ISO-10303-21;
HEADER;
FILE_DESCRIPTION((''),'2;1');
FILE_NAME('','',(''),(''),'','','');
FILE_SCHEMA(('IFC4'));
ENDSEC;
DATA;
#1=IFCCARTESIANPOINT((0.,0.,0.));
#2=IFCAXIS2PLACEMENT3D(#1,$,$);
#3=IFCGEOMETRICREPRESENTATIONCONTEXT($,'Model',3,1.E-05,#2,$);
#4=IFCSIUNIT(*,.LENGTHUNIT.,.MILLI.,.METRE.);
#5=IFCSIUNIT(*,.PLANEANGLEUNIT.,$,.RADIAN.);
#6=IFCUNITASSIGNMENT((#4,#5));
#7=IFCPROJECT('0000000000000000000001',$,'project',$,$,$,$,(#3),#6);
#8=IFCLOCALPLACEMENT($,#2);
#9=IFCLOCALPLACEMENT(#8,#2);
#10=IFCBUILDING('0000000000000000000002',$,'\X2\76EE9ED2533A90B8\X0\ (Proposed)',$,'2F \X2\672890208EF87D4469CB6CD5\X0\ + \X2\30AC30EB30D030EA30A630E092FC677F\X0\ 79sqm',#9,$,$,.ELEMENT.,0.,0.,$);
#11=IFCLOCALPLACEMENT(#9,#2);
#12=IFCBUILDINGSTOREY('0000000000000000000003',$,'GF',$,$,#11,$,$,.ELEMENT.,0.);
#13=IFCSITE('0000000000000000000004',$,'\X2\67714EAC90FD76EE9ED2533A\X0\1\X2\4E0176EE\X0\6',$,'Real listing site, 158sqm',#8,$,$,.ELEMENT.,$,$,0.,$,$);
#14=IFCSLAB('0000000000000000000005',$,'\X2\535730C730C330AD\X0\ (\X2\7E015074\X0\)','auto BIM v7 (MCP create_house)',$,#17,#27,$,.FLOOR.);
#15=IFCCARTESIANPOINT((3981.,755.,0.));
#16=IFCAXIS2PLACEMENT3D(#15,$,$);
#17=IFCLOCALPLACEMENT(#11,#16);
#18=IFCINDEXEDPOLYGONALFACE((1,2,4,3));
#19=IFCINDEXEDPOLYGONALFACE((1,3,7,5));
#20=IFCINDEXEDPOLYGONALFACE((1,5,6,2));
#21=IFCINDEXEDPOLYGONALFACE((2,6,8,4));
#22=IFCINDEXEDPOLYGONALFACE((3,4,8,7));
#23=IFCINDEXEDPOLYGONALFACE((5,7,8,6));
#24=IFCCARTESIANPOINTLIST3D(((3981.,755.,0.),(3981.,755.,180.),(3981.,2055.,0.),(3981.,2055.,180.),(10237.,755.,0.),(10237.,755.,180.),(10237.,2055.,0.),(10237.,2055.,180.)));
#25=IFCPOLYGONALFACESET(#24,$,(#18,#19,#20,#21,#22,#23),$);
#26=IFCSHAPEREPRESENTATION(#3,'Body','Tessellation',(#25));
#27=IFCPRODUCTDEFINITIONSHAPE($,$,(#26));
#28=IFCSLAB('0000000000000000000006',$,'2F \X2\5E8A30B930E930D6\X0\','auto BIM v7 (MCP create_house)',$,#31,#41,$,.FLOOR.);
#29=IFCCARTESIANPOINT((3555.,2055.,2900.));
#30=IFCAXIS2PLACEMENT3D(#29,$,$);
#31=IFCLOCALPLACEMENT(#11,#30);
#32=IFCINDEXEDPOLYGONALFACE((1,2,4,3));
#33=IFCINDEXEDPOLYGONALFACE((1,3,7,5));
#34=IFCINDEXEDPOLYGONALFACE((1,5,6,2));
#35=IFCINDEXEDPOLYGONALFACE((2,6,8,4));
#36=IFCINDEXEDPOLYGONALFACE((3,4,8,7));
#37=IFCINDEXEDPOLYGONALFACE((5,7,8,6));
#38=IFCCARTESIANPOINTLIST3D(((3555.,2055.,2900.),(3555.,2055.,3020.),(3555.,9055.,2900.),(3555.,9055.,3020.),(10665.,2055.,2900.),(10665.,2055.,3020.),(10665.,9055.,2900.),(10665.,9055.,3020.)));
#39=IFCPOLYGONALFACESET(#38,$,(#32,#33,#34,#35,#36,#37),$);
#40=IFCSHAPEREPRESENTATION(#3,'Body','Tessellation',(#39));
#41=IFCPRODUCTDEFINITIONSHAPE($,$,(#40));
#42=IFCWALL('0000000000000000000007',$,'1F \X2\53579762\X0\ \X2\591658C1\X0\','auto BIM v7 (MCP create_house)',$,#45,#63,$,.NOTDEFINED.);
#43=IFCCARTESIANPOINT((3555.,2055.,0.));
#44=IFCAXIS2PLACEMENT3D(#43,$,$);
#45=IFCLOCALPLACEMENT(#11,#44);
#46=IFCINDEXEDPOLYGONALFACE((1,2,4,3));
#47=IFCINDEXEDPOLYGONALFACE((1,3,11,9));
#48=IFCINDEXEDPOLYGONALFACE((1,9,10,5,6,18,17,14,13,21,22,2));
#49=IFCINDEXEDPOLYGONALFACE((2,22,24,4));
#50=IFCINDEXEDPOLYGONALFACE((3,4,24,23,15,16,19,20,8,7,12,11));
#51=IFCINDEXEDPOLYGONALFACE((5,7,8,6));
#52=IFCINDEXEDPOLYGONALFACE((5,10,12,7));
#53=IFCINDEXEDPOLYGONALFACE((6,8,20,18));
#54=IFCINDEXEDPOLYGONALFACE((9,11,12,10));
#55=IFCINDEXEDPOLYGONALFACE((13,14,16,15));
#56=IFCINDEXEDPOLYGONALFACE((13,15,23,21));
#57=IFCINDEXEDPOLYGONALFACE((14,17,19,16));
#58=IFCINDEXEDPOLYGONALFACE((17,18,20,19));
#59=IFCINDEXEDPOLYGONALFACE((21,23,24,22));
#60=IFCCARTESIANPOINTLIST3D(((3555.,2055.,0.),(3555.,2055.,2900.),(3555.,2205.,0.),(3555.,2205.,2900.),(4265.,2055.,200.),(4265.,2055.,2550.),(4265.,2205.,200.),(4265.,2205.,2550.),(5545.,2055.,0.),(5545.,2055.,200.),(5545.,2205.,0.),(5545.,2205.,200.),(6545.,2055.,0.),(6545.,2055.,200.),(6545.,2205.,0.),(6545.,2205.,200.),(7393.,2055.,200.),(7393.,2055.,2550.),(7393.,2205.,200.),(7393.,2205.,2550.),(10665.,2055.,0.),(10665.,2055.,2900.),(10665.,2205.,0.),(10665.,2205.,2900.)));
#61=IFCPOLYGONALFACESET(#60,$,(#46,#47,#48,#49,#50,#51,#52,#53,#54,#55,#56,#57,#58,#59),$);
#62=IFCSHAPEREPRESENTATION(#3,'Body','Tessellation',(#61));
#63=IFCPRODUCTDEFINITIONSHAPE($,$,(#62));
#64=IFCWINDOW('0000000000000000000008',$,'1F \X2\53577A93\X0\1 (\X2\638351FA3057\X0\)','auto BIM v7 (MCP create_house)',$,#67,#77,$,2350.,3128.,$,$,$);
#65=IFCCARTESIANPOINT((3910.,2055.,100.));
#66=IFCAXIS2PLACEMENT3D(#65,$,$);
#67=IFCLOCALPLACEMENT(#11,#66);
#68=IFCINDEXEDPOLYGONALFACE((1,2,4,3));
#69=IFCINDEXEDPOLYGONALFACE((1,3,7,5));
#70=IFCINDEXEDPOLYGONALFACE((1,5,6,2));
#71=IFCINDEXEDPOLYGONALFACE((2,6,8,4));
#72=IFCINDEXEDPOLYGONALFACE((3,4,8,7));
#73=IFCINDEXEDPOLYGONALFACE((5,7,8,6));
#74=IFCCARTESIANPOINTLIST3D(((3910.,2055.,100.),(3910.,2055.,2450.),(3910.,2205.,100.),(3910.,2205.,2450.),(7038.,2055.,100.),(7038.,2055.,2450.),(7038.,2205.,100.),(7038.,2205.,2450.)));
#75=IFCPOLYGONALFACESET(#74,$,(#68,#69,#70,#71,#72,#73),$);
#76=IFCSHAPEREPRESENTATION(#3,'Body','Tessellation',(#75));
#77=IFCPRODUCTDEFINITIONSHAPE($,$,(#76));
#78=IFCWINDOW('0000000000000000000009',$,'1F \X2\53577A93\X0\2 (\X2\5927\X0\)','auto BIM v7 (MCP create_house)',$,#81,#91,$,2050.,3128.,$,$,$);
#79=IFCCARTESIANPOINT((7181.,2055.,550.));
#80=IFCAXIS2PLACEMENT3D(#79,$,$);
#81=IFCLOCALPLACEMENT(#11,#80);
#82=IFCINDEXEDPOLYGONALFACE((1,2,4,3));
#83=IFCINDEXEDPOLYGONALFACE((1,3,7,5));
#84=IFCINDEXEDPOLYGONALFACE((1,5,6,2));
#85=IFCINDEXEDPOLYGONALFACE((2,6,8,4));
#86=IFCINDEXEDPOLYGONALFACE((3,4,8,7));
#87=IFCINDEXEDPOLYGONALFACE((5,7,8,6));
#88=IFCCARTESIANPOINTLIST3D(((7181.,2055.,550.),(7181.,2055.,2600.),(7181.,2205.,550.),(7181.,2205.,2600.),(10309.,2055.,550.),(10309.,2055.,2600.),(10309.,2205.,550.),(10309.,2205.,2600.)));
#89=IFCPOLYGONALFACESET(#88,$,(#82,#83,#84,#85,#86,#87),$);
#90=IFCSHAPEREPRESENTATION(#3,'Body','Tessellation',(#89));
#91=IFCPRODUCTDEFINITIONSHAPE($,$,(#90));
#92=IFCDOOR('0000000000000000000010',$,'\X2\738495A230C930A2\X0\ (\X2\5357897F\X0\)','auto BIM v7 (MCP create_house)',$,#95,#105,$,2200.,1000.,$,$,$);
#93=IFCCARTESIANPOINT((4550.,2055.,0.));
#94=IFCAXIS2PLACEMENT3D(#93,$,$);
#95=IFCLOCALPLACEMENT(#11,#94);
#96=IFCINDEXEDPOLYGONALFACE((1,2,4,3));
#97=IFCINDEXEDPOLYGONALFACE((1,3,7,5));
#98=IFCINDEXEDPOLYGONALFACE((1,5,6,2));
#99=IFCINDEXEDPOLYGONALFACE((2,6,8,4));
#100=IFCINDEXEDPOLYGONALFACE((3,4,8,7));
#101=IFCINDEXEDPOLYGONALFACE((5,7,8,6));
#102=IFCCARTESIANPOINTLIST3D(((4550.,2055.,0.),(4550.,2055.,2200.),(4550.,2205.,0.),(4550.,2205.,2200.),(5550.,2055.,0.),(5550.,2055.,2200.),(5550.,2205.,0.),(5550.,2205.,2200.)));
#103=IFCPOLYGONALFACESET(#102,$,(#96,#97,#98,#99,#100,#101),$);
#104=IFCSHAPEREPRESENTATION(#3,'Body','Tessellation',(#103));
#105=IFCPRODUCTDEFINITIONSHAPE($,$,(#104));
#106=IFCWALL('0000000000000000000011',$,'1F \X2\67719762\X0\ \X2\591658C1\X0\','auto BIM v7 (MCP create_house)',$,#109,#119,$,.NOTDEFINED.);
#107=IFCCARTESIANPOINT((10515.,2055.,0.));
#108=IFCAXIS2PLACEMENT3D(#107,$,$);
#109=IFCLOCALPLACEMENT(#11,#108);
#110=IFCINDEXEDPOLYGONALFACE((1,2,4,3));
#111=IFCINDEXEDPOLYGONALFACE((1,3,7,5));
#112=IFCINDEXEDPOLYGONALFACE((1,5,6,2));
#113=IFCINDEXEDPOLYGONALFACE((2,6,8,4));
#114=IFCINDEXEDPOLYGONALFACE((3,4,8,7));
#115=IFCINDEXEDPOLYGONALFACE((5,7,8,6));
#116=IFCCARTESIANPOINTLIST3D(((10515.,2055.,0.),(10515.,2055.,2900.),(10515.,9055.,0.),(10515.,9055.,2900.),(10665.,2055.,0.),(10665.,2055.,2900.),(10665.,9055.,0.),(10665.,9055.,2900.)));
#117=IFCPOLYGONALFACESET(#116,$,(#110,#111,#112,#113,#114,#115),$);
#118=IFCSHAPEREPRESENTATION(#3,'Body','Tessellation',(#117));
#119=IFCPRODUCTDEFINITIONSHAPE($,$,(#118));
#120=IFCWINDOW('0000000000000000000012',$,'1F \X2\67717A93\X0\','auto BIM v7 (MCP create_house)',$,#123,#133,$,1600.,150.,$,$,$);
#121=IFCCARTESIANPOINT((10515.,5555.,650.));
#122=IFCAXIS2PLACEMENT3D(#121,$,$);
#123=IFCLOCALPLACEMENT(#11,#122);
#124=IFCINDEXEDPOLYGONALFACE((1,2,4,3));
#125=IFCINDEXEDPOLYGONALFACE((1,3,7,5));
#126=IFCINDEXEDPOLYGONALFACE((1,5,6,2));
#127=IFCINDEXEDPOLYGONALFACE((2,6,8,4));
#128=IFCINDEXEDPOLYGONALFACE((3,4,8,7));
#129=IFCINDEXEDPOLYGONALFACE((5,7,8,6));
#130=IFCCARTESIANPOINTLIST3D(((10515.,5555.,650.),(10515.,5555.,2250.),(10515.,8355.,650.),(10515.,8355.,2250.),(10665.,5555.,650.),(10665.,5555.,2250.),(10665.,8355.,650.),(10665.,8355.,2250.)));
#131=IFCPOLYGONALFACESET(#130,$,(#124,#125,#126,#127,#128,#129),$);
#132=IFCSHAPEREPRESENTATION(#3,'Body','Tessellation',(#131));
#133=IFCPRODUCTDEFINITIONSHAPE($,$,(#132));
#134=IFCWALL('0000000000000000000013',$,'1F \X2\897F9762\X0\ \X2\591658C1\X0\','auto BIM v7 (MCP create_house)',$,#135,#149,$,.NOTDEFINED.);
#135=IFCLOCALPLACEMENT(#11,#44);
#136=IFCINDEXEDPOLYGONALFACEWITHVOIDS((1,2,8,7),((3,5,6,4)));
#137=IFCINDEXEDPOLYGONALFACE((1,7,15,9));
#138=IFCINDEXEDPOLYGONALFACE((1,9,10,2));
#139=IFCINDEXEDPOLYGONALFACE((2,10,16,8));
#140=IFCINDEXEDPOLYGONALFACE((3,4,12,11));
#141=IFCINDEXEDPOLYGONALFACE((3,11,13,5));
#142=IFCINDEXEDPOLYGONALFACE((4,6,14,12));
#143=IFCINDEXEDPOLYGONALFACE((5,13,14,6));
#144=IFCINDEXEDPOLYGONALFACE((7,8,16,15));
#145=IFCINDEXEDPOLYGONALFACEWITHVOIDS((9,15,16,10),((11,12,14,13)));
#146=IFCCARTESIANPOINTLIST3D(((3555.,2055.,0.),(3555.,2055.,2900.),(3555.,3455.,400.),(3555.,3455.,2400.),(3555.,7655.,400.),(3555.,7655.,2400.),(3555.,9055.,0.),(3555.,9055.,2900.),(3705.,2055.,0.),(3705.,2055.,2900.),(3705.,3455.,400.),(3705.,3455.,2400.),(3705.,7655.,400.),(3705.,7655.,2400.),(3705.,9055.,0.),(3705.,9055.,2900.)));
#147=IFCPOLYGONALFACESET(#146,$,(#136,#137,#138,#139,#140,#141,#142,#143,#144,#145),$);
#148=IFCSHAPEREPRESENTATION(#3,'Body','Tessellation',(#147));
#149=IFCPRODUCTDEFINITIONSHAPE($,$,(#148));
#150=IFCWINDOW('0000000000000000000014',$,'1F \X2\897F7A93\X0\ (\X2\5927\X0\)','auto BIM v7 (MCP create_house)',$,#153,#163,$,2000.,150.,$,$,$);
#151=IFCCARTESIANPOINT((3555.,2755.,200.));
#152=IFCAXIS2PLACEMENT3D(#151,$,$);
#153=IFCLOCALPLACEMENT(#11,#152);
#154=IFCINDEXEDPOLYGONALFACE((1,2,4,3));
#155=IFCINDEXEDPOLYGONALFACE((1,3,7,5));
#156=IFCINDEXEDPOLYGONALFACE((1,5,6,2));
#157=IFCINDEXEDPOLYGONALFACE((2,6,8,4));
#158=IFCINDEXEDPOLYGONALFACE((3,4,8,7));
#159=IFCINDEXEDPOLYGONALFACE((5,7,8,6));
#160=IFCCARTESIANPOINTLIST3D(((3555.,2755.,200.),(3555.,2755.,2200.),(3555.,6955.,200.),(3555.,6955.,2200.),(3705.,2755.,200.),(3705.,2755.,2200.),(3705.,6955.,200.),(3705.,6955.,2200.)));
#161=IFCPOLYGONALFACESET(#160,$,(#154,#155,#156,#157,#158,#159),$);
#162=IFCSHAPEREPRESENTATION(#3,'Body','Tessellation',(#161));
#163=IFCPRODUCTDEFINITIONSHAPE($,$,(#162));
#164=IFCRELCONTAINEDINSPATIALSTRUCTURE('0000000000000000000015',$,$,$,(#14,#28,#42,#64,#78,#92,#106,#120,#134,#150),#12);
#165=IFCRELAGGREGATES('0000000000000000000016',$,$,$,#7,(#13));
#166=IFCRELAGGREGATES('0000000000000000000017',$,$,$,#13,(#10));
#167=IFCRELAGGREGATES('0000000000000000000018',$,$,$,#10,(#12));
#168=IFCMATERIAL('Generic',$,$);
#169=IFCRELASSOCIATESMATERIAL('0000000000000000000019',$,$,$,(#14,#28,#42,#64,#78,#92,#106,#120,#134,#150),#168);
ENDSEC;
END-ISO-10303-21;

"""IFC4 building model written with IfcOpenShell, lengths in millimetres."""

from ifc_helpers import new_model, si_unit, frame, frame_2d, origin, place, context, project, spatial, rectangle, extrude, material, element, fill, save


model = new_model("IFC4")

# Units and contexts
model_context = context("Model", 3, precision=1e-05, world=origin())
ifc_project = project(units=[si_unit("LENGTHUNIT", "METRE", prefix="MILLI"), si_unit("PLANEANGLEUNIT", "RADIAN")], contexts=[model_context])

# Site, building, storey
site_placement = place(None, origin())
site = spatial("IfcSite", under=ifc_project, at=site_placement, Name="東京都目黒区1丁目6", ObjectType="Real listing site, 158sqm", CompositionType="ELEMENT", RefElevation=0.0)
building_placement = place(site_placement, origin())
building = spatial("IfcBuilding", under=site, at=building_placement, Name="目黒区邸 (Proposed)", ObjectType="2F 木造軸組構法 + ガルバリウム鋼板 79sqm", CompositionType="ELEMENT", ElevationOfRefHeight=0.0, ElevationOfTerrain=0.0)
storey_placement = place(building_placement, origin())
storey = spatial("IfcBuildingStorey", under=building, at=storey_placement, Name="GF", CompositionType="ELEMENT", Elevation=0.0)

# Slabs
ifc_material = material(Name="Generic")
slab_1_placement = place(storey_placement, frame((3981.0, 755.0, 0.0)))
element("IfcSlab", 1, at=slab_1_placement, inside=storey, material=ifc_material, Name="南デッキ (縁側)", Description="auto BIM v7 (MCP create_house)", PredefinedType="FLOOR", context=model_context, shape_type="SweptSolid", body=[
    extrude(rectangle(XDim=6256.0, YDim=1300.0, at=frame_2d((3128.0, 650.0))), frame((3981.0, 755.0, 0.0)), (0.0, 0.0, 1.0), 180.0),
])
slab_2_placement = place(storey_placement, frame((3555.0, 2055.0, 2900.0)))
element("IfcSlab", 2, at=slab_2_placement, inside=storey, material=ifc_material, Name="2F 床スラブ", Description="auto BIM v7 (MCP create_house)", PredefinedType="FLOOR", context=model_context, shape_type="SweptSolid", body=[
    extrude(rectangle(XDim=7110.0, YDim=7000.0, at=frame_2d((3555.0, 3500.0))), frame((3555.0, 2055.0, 2900.0)), (0.0, 0.0, 1.0), 120.0),
])

# Wall, openings, windows, door
wall_1_placement = place(storey_placement, frame((3555.0, 2055.0, 0.0)))
wall_1 = element("IfcWall", 3, at=wall_1_placement, inside=storey, material=ifc_material, Name="1F 南面 外壁", Description="auto BIM v7 (MCP create_house)", PredefinedType="NOTDEFINED", context=model_context, shape_type="SweptSolid", body=[
    extrude(rectangle(XDim=7110.0, YDim=150.0, at=frame_2d((3555.0, 75.0))), frame((3555.0, 2055.0, 0.0)), (0.0, 0.0, 1.0), 2900.0),
])
opening_1_placement = place(storey_placement, frame((3910.0, 2055.0, 100.0)))
opening_1 = element("IfcOpeningElement", 4, at=opening_1_placement, cuts=wall_1, PredefinedType="NOTDEFINED", context=model_context, shape_type="SweptSolid", body=[
    extrude(rectangle(XDim=3128.0, YDim=150.0, at=frame_2d((1564.0, 75.0))), frame((3910.0, 2055.0, 100.0)), (0.0, 0.0, 1.0), 2350.0),
])
opening_2_placement = place(storey_placement, frame((7181.0, 2055.0, 550.0)))
opening_2 = element("IfcOpeningElement", 5, at=opening_2_placement, cuts=wall_1, PredefinedType="NOTDEFINED", context=model_context, shape_type="SweptSolid", body=[
    extrude(rectangle(XDim=3128.0, YDim=150.0, at=frame_2d((1564.0, 75.0))), frame((7181.0, 2055.0, 550.0)), (0.0, 0.0, 1.0), 2050.0),
])
opening_3_placement = place(storey_placement, frame((4550.0, 2055.0, 0.0)))
opening_3 = element("IfcOpeningElement", 6, at=opening_3_placement, cuts=wall_1, PredefinedType="NOTDEFINED", context=model_context, shape_type="SweptSolid", body=[
    extrude(rectangle(XDim=1000.0, YDim=150.0, at=frame_2d((500.0, 75.0))), frame((4550.0, 2055.0, 0.0)), (0.0, 0.0, 1.0), 2200.0),
])
window_1_placement = place(storey_placement, frame((3910.0, 2055.0, 100.0)))
window_1 = element("IfcWindow", 7, at=window_1_placement, inside=storey, material=ifc_material, Name="1F 南窓1 (掃出し)", Description="auto BIM v7 (MCP create_house)", OverallHeight=2350.0, OverallWidth=3128.0, context=model_context, shape_type="SweptSolid", body=[
    extrude(rectangle(XDim=3128.0, YDim=150.0, at=frame_2d((1564.0, 75.0))), frame((3910.0, 2055.0, 100.0)), (0.0, 0.0, 1.0), 2350.0),
])
fill(opening_1, window_1)
window_2_placement = place(storey_placement, frame((7181.0, 2055.0, 550.0)))
window_2 = element("IfcWindow", 8, at=window_2_placement, inside=storey, material=ifc_material, Name="1F 南窓2 (大)", Description="auto BIM v7 (MCP create_house)", OverallHeight=2050.0, OverallWidth=3128.0, context=model_context, shape_type="SweptSolid", body=[
    extrude(rectangle(XDim=3128.0, YDim=150.0, at=frame_2d((1564.0, 75.0))), frame((7181.0, 2055.0, 550.0)), (0.0, 0.0, 1.0), 2050.0),
])
fill(opening_2, window_2)
door_placement = place(storey_placement, frame((4550.0, 2055.0, 0.0)))
door = element("IfcDoor", 9, at=door_placement, inside=storey, material=ifc_material, Name="玄関ドア (南西)", Description="auto BIM v7 (MCP create_house)", OverallHeight=2200.0, OverallWidth=1000.0, context=model_context, shape_type="SweptSolid", body=[
    extrude(rectangle(XDim=1000.0, YDim=150.0, at=frame_2d((500.0, 75.0))), frame((4550.0, 2055.0, 0.0)), (0.0, 0.0, 1.0), 2200.0),
])
fill(opening_3, door)

# Walls, openings, windows
wall_2_placement = place(storey_placement, frame((10515.0, 2055.0, 0.0)))
wall_2 = element("IfcWall", 10, at=wall_2_placement, inside=storey, material=ifc_material, Name="1F 東面 外壁", Description="auto BIM v7 (MCP create_house)", PredefinedType="NOTDEFINED", context=model_context, shape_type="SweptSolid", body=[
    extrude(rectangle(XDim=150.0, YDim=7000.0, at=frame_2d((75.0, 3500.0))), frame((10515.0, 2055.0, 0.0)), (0.0, 0.0, 1.0), 2900.0),
])
opening_4_placement = place(storey_placement, frame((10515.0, 5555.0, 650.0)))
opening_4 = element("IfcOpeningElement", 11, at=opening_4_placement, cuts=wall_2, PredefinedType="NOTDEFINED", context=model_context, shape_type="SweptSolid", body=[
    extrude(rectangle(XDim=150.0, YDim=2800.0, at=frame_2d((75.0, 1400.0))), frame((10515.0, 5555.0, 650.0)), (0.0, 0.0, 1.0), 1600.0),
])
window_3_placement = place(storey_placement, frame((10515.0, 5555.0, 650.0)))
window_3 = element("IfcWindow", 12, at=window_3_placement, inside=storey, material=ifc_material, Name="1F 東窓", Description="auto BIM v7 (MCP create_house)", OverallHeight=1600.0, OverallWidth=150.0, context=model_context, shape_type="SweptSolid", body=[
    extrude(rectangle(XDim=150.0, YDim=2800.0, at=frame_2d((75.0, 1400.0))), frame((10515.0, 5555.0, 650.0)), (0.0, 0.0, 1.0), 1600.0),
])
fill(opening_4, window_3)
wall_3_placement = place(storey_placement, frame((3555.0, 2055.0, 0.0)))
wall_3 = element("IfcWall", 13, at=wall_3_placement, inside=storey, material=ifc_material, Name="1F 西面 外壁", Description="auto BIM v7 (MCP create_house)", PredefinedType="NOTDEFINED", context=model_context, shape_type="SweptSolid", body=[
    extrude(rectangle(XDim=150.0, YDim=7000.0, at=frame_2d((75.0, 3500.0))), frame((3555.0, 2055.0, 0.0)), (0.0, 0.0, 1.0), 2900.0),
])
opening_5_placement = place(storey_placement, frame((3555.0, 2755.0, 200.0)))
opening_5 = element("IfcOpeningElement", 14, at=opening_5_placement, cuts=wall_3, PredefinedType="NOTDEFINED", context=model_context, shape_type="SweptSolid", body=[
    extrude(rectangle(XDim=150.0, YDim=4200.0, at=frame_2d((75.0, 2100.0))), frame((3555.0, 2755.0, 200.0)), (0.0, 0.0, 1.0), 2000.0),
])
window_4_placement = place(storey_placement, frame((3555.0, 2755.0, 200.0)))
window_4 = element("IfcWindow", 15, at=window_4_placement, inside=storey, material=ifc_material, Name="1F 西窓 (大)", Description="auto BIM v7 (MCP create_house)", OverallHeight=2000.0, OverallWidth=150.0, context=model_context, shape_type="SweptSolid", body=[
    extrude(rectangle(XDim=150.0, YDim=4200.0, at=frame_2d((75.0, 2100.0))), frame((3555.0, 2755.0, 200.0)), (0.0, 0.0, 1.0), 2000.0),
])
fill(opening_5, window_4)

save(model, "model.ifc")
